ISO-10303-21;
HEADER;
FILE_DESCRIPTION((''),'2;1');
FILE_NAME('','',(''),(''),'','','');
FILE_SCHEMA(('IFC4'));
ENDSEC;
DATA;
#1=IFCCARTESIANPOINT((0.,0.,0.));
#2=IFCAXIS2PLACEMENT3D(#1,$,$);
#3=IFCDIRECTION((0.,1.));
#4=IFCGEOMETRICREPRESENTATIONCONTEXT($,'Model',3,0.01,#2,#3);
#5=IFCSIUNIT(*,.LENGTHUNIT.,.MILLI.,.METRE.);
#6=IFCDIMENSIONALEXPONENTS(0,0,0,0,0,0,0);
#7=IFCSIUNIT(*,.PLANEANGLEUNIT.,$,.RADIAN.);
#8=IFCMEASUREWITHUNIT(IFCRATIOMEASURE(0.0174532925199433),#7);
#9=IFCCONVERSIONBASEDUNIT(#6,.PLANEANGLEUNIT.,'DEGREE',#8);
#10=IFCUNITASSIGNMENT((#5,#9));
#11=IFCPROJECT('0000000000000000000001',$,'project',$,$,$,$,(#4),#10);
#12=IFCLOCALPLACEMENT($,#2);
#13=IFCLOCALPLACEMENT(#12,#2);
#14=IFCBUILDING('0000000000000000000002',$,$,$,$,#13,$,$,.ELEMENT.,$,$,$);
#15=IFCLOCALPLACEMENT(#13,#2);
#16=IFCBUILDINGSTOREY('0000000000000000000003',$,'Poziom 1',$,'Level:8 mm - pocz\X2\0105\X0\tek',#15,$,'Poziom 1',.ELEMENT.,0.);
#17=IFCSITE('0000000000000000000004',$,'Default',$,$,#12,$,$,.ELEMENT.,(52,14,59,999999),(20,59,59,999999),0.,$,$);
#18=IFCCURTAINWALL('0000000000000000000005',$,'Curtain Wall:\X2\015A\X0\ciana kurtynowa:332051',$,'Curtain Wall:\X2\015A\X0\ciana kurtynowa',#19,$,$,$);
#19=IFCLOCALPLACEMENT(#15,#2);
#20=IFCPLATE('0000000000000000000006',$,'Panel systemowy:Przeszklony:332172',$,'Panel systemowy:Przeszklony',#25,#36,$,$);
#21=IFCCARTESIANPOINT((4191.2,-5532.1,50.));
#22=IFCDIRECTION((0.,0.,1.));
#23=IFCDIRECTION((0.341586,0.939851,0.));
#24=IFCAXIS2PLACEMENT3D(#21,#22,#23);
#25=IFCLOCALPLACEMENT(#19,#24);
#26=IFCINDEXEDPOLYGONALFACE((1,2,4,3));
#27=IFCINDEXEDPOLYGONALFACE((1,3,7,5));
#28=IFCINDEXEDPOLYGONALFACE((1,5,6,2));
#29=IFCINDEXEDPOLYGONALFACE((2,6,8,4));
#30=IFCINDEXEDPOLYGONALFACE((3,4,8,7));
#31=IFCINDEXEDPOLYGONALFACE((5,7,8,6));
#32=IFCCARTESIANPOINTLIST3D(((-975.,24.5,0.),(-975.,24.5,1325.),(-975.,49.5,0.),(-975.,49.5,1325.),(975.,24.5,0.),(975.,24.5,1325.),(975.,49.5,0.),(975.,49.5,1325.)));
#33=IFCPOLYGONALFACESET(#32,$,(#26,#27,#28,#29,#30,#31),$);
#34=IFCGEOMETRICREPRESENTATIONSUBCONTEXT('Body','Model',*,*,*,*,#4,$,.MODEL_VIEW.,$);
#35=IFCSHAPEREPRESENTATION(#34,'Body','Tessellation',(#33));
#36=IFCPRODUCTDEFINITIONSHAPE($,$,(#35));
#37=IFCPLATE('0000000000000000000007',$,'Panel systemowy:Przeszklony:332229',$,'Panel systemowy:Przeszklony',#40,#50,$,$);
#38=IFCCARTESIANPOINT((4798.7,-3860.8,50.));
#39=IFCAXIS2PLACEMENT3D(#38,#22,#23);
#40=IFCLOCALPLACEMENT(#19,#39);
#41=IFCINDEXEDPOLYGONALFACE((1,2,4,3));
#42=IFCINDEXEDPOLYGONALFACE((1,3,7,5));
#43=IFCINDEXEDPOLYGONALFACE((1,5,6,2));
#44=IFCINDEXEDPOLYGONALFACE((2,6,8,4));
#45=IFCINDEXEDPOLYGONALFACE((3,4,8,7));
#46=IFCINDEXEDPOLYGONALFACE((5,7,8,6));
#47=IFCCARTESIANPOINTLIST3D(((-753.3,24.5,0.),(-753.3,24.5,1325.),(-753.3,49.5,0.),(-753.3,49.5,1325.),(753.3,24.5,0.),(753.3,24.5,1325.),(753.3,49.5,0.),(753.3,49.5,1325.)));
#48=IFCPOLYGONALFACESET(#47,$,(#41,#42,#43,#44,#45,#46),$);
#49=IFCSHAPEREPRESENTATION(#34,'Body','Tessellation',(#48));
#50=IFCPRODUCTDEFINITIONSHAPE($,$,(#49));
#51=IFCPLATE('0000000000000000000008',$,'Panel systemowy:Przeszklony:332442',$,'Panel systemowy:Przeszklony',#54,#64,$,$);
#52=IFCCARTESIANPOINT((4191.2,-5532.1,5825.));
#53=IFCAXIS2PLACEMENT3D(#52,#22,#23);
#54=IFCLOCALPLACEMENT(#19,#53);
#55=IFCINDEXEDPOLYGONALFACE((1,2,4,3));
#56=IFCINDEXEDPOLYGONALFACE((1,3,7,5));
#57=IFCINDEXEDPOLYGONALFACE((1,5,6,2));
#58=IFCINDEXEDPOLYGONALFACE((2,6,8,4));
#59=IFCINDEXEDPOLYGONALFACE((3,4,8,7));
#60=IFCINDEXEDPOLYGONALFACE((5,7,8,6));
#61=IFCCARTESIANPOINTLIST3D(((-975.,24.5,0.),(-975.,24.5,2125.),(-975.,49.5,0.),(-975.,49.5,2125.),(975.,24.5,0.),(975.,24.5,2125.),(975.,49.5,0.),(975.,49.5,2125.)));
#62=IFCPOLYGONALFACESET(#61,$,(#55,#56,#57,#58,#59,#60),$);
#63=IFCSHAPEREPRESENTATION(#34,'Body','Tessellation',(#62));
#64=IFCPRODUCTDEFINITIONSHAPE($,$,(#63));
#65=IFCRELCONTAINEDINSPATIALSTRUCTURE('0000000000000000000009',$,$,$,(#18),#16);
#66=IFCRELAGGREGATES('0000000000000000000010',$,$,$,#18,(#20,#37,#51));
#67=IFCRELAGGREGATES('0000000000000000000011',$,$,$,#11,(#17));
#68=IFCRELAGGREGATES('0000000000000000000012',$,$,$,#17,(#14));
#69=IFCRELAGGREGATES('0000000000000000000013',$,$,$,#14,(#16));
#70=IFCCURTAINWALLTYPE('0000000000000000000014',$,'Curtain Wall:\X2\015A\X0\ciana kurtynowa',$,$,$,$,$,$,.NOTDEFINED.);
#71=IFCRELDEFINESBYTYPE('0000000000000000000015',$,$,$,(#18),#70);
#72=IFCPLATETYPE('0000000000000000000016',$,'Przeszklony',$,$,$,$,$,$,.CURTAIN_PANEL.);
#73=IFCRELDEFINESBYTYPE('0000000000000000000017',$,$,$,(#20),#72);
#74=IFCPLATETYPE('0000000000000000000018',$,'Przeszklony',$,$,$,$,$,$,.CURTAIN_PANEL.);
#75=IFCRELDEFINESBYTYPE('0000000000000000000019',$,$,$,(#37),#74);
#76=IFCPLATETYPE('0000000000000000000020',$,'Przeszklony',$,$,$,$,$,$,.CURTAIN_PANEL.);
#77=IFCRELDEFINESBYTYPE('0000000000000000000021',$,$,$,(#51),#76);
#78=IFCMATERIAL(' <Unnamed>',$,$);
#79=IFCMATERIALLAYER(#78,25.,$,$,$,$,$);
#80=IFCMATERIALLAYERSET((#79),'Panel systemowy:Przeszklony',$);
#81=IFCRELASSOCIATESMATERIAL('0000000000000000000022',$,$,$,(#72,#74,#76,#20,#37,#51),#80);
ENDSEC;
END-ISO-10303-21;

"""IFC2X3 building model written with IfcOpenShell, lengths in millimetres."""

from ifc_helpers import new_model, entity, si_unit, converted_unit, direction, frame, frame_2d, origin, origin_2d_with_axis, place, context, subcontext, project, spatial, rectangle, extrude, source, transform, mapped, material, layer, layer_set, layer_usage, type_object, type_shapes, element, aggregate, save


model = new_model("IFC2X3")

# Units and contexts
model_context = context("Model", 3, precision=0.01, world=origin(), true_north=direction((0.0, 1.0)))
body_context = subcontext(model_context, "Body", "Model", "MODEL_VIEW")
ifc_project = project(units=[si_unit("LENGTHUNIT", "METRE", prefix="MILLI"), converted_unit("PLANEANGLEUNIT", "DEGREE", entity("IfcRatioMeasure", 0.0174532925199433), si_unit("PLANEANGLEUNIT", "RADIAN"), dimensions=[0, 0, 0, 0, 0, 0, 0])], contexts=[model_context])

# Site, building, storey
site_placement = place(None, origin())
site = spatial("IfcSite", under=ifc_project, at=site_placement, Name="Default", CompositionType="ELEMENT", RefLatitude=(52, 14, 59, 999999), RefLongitude=(20, 59, 59, 999999), RefElevation=0.0)
building_placement = place(site_placement, origin())
building = spatial("IfcBuilding", under=site, at=building_placement, CompositionType="ELEMENT")
storey_placement = place(building_placement, origin())
storey = spatial("IfcBuildingStorey", under=building, at=storey_placement, Name="Poziom 1", ObjectType="Level:8 mm - początek", LongName="Poziom 1", CompositionType="ELEMENT", Elevation=0.0)

# Curtain wall, plates
curtain_wall_type = type_object("IfcCurtainWallType", Name="Curtain Wall:Ściana kurtynowa", PredefinedType="NOTDEFINED")
curtain_wall_placement = place(storey_placement, origin())
curtain_wall = element("IfcCurtainWall", 1, at=curtain_wall_placement, inside=storey, type_object=curtain_wall_type, Name="Curtain Wall:Ściana kurtynowa:332051", ObjectType="Curtain Wall:Ściana kurtynowa")
ifc_material_1 = material(Name=" <Unnamed>")
ifc_layer = layer(ifc_material_1, 25.0)
ifc_layer_set = layer_set([ifc_layer], Name="Panel systemowy:Przeszklony")
ifc_layer_usage_1 = layer_usage(ifc_layer_set, "AXIS3", "POSITIVE", 0.1)
plate_type_1 = type_object("IfcPlateType", Name="Przeszklony", PredefinedType="CURTAIN_PANEL", material=ifc_layer_set)
shared_shape_1 = source(origin(), body_context, "Body", "SweptSolid", [
    extrude(rectangle(XDim=25.0, YDim=1950.0, at=origin_2d_with_axis()), frame((0.0, 37.0, 0.0), z_axis=(0.0, 0.0, 1.0), x_axis=(0.0, 1.0, 0.0)), (0.0, 0.0, 1.0), 1325.0),
])
type_shapes(plate_type_1, [shared_shape_1])
plate_1_placement = place(curtain_wall_placement, frame((4191.2, -5532.1, 50.0), z_axis=(0.0, 0.0, 1.0), x_axis=(0.341586, 0.939851, 0.0)))
plate_1 = element("IfcPlate", 2, at=plate_1_placement, type_object=plate_type_1, material=ifc_layer_usage_1, Name="Panel systemowy:Przeszklony:332172", ObjectType="Panel systemowy:Przeszklony", context=body_context, shape_type="MappedRepresentation", body=[
    mapped(shared_shape_1, transform((0.0, 0.0, 0.0), scale=1.0)),
])
ifc_layer_usage_2 = layer_usage(ifc_layer_set, "AXIS3", "POSITIVE", 0.1)
plate_type_2 = type_object("IfcPlateType", Name="Przeszklony", PredefinedType="CURTAIN_PANEL", material=ifc_layer_set)
shared_shape_2 = source(origin(), body_context, "Body", "SweptSolid", [
    extrude(rectangle(XDim=25.0, YDim=1506.6, at=origin_2d_with_axis()), frame((0.0, 37.0, 0.0), z_axis=(0.0, 0.0, 1.0), x_axis=(0.0, 1.0, 0.0)), (0.0, 0.0, 1.0), 1325.0),
])
type_shapes(plate_type_2, [shared_shape_2])
plate_2_placement = place(curtain_wall_placement, frame((4798.7, -3860.8, 50.0), z_axis=(0.0, 0.0, 1.0), x_axis=(0.341586, 0.939851, 0.0)))
plate_2 = element("IfcPlate", 3, at=plate_2_placement, type_object=plate_type_2, material=ifc_layer_usage_2, Name="Panel systemowy:Przeszklony:332229", ObjectType="Panel systemowy:Przeszklony", context=body_context, shape_type="MappedRepresentation", body=[
    mapped(shared_shape_2, transform((0.0, 0.0, 0.0), scale=1.0)),
])
ifc_layer_usage_3 = layer_usage(ifc_layer_set, "AXIS3", "POSITIVE", 0.1)
plate_type_3 = type_object("IfcPlateType", Name="Przeszklony", PredefinedType="CURTAIN_PANEL", material=ifc_layer_set)
shared_shape_3 = source(origin(), body_context, "Body", "SweptSolid", [
    extrude(rectangle(XDim=25.0, YDim=1950.0, at=frame_2d((0.0, 0.0), x_axis=(1.0, 0.0))), frame((0.0, 37.0, 0.0), z_axis=(0.0, 0.0, 1.0), x_axis=(0.0, 1.0, 0.0)), (0.0, 0.0, 1.0), 2125.0),
])
type_shapes(plate_type_3, [shared_shape_3])
plate_3_placement = place(curtain_wall_placement, frame((4191.2, -5532.1, 5825.0), z_axis=(0.0, 0.0, 1.0), x_axis=(0.341586, 0.939851, 0.0)))
plate_3 = element("IfcPlate", 4, at=plate_3_placement, type_object=plate_type_3, material=ifc_layer_usage_3, Name="Panel systemowy:Przeszklony:332442", ObjectType="Panel systemowy:Przeszklony", context=body_context, shape_type="MappedRepresentation", body=[
    mapped(shared_shape_3, transform((0.0, 0.0, 0.0), scale=1.0)),
])
aggregate(curtain_wall, [plate_1, plate_2, plate_3])

save(model, "model.ifc")
